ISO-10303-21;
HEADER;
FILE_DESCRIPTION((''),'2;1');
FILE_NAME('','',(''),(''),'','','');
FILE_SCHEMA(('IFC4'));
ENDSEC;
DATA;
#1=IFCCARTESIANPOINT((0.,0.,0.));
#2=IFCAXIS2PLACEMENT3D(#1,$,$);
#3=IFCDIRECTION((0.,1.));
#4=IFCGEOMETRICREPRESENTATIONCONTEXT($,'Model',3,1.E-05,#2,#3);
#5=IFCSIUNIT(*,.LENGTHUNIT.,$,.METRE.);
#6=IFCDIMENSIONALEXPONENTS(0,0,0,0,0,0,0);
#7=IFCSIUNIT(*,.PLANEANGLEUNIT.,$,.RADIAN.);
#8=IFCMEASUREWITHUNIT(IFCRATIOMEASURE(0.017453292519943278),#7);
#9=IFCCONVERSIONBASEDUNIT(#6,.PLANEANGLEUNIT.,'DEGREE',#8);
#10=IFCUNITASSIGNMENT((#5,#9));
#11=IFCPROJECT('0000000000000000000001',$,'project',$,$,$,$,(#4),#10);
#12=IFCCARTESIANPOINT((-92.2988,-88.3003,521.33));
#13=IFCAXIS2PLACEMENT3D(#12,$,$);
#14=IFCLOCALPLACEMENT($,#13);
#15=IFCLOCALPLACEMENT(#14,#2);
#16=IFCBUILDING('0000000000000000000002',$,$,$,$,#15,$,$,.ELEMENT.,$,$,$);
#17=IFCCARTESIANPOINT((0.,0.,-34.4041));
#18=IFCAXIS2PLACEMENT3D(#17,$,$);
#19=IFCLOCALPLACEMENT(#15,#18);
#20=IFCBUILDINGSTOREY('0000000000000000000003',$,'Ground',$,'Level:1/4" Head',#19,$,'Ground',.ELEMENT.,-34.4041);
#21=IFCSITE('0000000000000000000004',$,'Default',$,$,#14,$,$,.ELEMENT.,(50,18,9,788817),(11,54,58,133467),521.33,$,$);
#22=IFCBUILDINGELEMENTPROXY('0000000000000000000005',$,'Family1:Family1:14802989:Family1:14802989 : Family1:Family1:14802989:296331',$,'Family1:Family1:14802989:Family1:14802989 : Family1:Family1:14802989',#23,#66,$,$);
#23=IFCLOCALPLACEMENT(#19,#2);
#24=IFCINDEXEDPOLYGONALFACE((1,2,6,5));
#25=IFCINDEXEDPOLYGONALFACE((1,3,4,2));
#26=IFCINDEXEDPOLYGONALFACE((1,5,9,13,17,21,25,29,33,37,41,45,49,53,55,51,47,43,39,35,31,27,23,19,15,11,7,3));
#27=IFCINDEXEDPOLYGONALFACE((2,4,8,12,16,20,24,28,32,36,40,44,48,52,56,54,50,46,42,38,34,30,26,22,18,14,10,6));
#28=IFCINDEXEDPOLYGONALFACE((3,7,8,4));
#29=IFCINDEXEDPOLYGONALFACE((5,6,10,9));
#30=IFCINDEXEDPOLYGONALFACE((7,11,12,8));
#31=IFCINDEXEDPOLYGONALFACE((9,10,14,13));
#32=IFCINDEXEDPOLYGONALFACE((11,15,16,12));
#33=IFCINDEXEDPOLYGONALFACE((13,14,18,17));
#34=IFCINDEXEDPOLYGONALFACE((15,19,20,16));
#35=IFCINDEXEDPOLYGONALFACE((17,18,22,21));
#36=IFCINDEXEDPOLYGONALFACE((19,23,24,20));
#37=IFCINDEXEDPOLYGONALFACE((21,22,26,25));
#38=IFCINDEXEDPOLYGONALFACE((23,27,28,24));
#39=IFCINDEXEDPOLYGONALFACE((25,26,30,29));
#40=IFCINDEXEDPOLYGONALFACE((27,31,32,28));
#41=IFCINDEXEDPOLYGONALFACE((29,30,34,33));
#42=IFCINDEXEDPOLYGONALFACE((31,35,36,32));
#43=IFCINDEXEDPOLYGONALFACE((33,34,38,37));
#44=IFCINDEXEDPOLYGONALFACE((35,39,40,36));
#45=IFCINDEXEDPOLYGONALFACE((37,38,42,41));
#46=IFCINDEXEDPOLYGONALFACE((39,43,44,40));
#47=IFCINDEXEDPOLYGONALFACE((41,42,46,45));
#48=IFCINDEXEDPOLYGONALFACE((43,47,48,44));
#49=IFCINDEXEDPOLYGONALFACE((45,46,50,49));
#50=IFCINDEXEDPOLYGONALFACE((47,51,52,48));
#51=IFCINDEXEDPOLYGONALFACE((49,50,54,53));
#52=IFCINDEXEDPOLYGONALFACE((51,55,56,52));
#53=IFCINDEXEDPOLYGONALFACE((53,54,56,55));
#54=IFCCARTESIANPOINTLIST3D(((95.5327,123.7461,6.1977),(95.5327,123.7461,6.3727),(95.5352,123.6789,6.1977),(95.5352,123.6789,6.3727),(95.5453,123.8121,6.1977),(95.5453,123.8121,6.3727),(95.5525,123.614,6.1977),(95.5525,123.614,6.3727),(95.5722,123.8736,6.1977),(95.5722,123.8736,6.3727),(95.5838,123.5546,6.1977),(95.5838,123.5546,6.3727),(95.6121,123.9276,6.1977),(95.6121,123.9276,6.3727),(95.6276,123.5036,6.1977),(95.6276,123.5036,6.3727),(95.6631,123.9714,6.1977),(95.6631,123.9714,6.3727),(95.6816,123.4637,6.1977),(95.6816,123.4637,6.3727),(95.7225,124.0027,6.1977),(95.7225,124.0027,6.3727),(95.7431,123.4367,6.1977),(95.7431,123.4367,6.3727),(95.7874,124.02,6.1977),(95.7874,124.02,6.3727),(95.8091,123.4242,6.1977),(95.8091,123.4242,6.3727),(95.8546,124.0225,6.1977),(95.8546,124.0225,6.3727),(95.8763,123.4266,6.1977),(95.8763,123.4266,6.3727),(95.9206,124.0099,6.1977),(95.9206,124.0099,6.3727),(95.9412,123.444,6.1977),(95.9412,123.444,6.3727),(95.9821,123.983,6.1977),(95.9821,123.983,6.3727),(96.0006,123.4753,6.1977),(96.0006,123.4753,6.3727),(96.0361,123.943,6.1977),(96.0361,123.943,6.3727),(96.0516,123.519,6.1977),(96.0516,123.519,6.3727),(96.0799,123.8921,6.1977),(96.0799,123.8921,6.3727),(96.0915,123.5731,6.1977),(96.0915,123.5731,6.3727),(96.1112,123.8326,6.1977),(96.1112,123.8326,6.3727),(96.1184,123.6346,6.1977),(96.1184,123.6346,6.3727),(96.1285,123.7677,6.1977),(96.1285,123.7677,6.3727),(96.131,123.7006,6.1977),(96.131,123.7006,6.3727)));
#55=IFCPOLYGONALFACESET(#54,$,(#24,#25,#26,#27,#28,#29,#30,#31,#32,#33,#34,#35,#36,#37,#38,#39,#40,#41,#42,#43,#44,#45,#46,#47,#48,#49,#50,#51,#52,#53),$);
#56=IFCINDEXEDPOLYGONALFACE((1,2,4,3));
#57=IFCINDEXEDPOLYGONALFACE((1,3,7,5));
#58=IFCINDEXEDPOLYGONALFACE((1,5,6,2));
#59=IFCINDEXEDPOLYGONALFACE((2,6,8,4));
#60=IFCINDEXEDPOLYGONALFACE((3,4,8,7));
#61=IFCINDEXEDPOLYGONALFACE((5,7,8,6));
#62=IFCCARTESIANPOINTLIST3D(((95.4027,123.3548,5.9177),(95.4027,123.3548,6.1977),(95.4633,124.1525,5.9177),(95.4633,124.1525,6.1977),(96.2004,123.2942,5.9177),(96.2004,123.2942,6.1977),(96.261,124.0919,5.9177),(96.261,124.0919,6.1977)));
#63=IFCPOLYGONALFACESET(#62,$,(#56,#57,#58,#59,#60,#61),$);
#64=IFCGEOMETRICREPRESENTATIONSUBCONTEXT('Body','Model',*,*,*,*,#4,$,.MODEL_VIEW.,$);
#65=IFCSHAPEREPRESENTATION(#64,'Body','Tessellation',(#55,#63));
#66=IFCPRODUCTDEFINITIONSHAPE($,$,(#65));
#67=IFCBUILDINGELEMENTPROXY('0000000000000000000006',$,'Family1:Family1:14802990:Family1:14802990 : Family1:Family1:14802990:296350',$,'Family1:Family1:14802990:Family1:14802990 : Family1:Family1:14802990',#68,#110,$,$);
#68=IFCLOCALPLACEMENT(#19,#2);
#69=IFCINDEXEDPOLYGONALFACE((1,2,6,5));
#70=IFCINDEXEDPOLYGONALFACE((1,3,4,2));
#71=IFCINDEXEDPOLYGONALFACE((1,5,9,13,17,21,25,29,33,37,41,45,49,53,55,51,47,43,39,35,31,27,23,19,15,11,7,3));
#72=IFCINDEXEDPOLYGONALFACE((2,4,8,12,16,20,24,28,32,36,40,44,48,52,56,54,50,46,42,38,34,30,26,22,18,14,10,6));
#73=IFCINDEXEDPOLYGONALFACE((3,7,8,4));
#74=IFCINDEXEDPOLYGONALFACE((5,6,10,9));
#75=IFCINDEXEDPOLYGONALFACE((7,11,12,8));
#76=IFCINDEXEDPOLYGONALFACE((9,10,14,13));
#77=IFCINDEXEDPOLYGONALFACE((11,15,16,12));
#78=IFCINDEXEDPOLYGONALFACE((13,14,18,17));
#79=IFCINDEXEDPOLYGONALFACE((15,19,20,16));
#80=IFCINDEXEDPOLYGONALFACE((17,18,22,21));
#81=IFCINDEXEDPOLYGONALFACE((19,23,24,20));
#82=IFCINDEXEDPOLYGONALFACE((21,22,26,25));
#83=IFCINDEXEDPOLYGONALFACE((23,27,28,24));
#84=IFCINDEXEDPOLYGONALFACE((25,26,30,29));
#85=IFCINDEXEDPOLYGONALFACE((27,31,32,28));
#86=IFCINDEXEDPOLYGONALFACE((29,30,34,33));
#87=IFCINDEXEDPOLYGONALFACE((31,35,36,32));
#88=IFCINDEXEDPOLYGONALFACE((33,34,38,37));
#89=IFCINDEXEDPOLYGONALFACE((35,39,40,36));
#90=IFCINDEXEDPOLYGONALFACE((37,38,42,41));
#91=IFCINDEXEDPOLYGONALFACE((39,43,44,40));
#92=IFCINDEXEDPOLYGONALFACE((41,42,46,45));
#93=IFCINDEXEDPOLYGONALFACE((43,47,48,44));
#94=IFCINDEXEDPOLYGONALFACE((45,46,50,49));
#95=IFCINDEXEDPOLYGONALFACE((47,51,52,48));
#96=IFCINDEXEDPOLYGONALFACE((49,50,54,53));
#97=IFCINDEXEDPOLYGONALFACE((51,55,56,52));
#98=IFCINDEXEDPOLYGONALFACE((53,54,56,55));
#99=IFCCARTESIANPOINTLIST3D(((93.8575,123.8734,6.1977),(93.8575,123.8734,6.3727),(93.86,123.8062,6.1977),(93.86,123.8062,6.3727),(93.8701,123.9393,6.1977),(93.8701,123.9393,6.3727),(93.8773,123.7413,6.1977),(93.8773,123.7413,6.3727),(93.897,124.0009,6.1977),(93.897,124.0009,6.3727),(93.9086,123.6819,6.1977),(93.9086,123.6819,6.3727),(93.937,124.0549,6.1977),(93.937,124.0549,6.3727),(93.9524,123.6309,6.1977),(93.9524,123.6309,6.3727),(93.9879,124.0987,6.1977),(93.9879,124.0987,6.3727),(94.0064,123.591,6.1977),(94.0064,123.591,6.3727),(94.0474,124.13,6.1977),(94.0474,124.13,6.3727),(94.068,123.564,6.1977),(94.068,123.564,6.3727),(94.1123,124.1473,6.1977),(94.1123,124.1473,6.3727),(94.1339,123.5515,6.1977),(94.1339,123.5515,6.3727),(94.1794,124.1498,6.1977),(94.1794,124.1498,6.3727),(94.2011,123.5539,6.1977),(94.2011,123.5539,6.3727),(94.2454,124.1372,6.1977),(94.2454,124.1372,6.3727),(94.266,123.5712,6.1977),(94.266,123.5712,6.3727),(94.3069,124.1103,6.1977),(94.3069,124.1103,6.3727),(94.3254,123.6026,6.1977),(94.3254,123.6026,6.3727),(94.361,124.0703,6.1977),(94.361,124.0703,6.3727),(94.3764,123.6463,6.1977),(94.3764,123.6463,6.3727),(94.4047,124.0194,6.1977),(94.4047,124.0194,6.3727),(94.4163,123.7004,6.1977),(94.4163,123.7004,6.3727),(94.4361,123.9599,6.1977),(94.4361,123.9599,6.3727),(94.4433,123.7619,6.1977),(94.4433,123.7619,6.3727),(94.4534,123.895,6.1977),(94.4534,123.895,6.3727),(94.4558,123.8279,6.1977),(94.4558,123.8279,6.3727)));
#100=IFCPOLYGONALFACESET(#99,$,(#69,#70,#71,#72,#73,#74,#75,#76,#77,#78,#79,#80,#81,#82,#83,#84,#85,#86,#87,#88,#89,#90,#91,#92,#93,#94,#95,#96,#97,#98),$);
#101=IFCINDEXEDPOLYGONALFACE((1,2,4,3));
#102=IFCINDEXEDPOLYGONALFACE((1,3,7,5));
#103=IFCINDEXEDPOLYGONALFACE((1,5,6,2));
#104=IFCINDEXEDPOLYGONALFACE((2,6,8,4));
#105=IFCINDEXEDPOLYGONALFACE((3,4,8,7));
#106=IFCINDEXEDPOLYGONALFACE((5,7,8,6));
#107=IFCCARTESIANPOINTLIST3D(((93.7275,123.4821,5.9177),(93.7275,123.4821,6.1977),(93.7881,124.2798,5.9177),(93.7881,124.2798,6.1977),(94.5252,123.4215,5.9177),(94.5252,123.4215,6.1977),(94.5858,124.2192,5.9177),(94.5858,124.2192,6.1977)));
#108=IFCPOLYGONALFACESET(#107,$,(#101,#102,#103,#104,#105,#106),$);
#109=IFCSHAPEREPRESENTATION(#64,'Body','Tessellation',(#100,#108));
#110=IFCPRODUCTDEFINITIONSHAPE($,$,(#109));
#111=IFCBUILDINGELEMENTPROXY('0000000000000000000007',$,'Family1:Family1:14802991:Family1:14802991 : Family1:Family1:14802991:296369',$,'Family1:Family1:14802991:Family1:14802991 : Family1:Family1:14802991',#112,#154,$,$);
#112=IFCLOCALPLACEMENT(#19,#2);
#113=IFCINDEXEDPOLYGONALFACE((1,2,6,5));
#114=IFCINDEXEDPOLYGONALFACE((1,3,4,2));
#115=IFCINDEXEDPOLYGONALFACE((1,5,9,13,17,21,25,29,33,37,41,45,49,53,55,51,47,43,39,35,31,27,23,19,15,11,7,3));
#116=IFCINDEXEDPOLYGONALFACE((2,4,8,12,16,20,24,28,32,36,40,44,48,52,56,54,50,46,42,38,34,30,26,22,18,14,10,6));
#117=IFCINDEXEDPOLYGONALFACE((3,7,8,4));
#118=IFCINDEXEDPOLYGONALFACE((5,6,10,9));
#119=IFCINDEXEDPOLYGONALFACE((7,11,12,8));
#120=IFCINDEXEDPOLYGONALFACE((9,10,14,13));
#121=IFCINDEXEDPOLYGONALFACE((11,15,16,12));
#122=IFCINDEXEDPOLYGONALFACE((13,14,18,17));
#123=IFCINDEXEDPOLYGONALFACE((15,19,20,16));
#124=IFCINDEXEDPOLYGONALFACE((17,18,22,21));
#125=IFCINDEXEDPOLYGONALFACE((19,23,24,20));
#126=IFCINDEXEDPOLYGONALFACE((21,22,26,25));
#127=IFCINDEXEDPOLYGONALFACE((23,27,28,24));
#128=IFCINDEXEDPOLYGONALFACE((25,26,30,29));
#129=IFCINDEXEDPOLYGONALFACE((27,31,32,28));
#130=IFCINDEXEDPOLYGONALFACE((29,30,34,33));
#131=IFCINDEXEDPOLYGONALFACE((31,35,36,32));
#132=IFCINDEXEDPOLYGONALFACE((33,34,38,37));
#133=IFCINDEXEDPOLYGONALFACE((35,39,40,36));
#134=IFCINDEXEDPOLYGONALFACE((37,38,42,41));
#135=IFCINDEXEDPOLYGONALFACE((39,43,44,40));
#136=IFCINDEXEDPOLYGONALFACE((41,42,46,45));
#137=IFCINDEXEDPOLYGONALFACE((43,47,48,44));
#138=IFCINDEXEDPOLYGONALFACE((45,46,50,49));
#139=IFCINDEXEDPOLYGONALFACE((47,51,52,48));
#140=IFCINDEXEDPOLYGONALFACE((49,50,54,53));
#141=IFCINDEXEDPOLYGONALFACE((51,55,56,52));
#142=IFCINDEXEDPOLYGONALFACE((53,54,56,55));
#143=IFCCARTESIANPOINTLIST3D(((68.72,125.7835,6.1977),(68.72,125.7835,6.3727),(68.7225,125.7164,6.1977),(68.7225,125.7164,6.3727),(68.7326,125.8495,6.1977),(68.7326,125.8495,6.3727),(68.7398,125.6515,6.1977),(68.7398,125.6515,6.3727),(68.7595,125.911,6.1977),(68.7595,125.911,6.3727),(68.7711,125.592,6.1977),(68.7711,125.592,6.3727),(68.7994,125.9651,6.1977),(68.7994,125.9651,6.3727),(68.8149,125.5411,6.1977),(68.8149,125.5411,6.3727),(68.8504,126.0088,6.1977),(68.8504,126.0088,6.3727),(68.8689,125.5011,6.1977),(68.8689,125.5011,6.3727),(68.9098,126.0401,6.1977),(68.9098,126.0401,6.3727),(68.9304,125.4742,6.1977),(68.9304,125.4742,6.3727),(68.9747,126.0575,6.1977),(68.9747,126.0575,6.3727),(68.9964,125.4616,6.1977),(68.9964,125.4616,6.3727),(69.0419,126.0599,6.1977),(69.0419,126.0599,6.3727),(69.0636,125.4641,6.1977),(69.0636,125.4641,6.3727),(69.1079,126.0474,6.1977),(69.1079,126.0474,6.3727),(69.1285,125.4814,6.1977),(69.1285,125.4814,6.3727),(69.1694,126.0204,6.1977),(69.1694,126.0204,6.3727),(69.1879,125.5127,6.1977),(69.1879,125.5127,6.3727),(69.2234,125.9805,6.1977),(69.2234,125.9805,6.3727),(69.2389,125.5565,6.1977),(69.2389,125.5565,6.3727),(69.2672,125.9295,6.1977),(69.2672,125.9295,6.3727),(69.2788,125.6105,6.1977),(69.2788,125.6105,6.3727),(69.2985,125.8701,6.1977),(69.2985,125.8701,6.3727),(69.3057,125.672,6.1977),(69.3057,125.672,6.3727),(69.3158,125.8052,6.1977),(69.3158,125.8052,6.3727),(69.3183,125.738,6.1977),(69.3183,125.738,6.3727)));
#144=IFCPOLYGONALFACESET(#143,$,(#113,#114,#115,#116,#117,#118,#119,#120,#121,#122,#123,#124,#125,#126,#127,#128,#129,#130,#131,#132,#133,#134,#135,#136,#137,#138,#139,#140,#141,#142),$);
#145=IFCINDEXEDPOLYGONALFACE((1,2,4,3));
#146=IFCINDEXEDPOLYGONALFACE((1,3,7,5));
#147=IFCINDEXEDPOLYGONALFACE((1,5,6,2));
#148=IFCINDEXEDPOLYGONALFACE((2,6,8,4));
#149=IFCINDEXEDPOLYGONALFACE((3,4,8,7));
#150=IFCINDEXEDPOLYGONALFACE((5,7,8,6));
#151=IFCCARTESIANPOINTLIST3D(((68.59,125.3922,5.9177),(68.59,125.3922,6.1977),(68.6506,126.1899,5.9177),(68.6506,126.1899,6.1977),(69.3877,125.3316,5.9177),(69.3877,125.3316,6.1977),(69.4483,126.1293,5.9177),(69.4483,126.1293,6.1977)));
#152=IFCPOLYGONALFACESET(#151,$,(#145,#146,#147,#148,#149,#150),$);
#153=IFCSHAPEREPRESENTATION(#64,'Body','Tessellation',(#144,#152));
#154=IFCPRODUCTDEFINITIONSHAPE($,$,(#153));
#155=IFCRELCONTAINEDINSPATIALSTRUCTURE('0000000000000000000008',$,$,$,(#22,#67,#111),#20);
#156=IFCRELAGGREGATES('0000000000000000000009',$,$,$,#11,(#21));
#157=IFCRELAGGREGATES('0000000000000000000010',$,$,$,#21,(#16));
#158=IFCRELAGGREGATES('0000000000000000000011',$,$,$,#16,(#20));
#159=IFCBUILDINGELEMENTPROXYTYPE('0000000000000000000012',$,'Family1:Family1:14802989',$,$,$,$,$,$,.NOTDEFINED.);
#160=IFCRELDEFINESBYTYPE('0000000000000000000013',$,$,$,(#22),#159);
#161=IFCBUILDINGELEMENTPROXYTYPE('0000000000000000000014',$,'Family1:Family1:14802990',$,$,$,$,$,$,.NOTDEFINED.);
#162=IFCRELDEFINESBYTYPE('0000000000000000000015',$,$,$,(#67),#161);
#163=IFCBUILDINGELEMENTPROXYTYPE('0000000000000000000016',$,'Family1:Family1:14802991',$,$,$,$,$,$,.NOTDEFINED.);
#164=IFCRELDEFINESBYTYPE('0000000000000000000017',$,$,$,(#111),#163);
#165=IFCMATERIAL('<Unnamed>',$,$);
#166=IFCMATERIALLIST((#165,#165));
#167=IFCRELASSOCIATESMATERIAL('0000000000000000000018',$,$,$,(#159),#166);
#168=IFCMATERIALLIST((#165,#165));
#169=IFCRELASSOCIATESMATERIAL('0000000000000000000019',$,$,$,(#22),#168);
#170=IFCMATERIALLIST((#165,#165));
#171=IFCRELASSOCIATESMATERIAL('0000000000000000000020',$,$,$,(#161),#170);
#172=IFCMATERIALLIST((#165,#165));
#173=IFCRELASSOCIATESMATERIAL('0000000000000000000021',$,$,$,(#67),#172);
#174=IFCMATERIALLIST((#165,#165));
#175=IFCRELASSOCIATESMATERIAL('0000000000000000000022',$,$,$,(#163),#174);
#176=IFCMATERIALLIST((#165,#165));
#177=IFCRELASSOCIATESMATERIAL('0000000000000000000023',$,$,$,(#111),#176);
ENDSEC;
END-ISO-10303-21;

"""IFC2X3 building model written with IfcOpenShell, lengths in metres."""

from ifc_helpers import new_model, entity, si_unit, converted_unit, direction, frame, frame_2d, origin, origin_2d_with_axis, place, context, subcontext, project, spatial, rectangle, circle, extrude, source, transform, mapped, material, material_list, type_object, type_shapes, element, save


model = new_model("IFC2X3")

# Units and contexts
model_context = context("Model", 3, precision=1e-05, world=origin(), true_north=direction((0.0, 1.0)))
body_context = subcontext(model_context, "Body", "Model", "MODEL_VIEW")
ifc_project = project(units=[si_unit("LENGTHUNIT", "METRE"), converted_unit("PLANEANGLEUNIT", "DEGREE", entity("IfcRatioMeasure", 0.017453292519943278), si_unit("PLANEANGLEUNIT", "RADIAN"), dimensions=[0, 0, 0, 0, 0, 0, 0])], contexts=[model_context])

# Site, building, storey
site_placement = place(None, frame((-92.2988, -88.3003, 521.33)))
site = spatial("IfcSite", under=ifc_project, at=site_placement, Name="Default", CompositionType="ELEMENT", RefLatitude=(50, 18, 9, 788817), RefLongitude=(11, 54, 58, 133467), RefElevation=521.33)
building_placement = place(site_placement, origin())
building = spatial("IfcBuilding", under=site, at=building_placement, CompositionType="ELEMENT")
storey_placement = place(building_placement, frame((0.0, 0.0, -34.4041)))
storey = spatial("IfcBuildingStorey", under=building, at=storey_placement, Name="Ground", ObjectType="Level:1/4\" Head", LongName="Ground", CompositionType="ELEMENT", Elevation=-34.4041)

# Building element proxies
ifc_material_1 = material(Name="<Unnamed>")
ifc_material_list_1 = material_list([ifc_material_1, ifc_material_1])
ifc_material_list_2 = material_list([ifc_material_1, ifc_material_1])
building_element_proxy_type_1 = type_object("IfcBuildingElementProxyType", Name="Family1:Family1:14802989", PredefinedType="NOTDEFINED", material=ifc_material_list_2)
shared_shape_1 = source(origin(), body_context, "Body", "SweptSolid", [
    extrude(circle(Radius=0.3, at=frame_2d((0.0, 0.0), x_axis=(1.0, 0.0))), frame((95.8318, 123.7233, -28.2064), z_axis=(0.0, 0.0, 1.0), x_axis=(0.997125, -0.07577, 0.0)), (0.0, 0.0, 1.0), 0.175),
    extrude(rectangle(XDim=0.8, YDim=0.8, at=frame_2d((0.0, 0.0), x_axis=(1.0, 0.0))), frame((95.8318, 123.7233, -28.4864), z_axis=(0.0, 0.0, 1.0), x_axis=(-0.07577, -0.997125, 0.0)), (0.0, 0.0, 1.0), 0.28),
])
type_shapes(building_element_proxy_type_1, [shared_shape_1])
proxy_1_placement = place(storey_placement, frame((0.0, 0.0, 34.4041)))
element("IfcBuildingElementProxy", 1, at=proxy_1_placement, inside=storey, type_object=building_element_proxy_type_1, material=ifc_material_list_1, Name="Family1:Family1:14802989:Family1:14802989 : Family1:Family1:14802989:296331", ObjectType="Family1:Family1:14802989:Family1:14802989 : Family1:Family1:14802989", context=body_context, shape_type="MappedRepresentation", body=[
    mapped(shared_shape_1, transform((0.0, 0.0, 0.0), scale=1.0)),
])
ifc_material_list_3 = material_list([ifc_material_1, ifc_material_1])
ifc_material_list_4 = material_list([ifc_material_1, ifc_material_1])
building_element_proxy_type_2 = type_object("IfcBuildingElementProxyType", Name="Family1:Family1:14802990", PredefinedType="NOTDEFINED", material=ifc_material_list_4)
shared_shape_2 = source(origin(), body_context, "Body", "SweptSolid", [
    extrude(circle(Radius=0.3, at=frame_2d((0.0, 0.0), x_axis=(1.0, 0.0))), frame((94.1567, 123.8506, -28.2064), z_axis=(0.0, 0.0, 1.0), x_axis=(0.997125, -0.07577, 0.0)), (0.0, 0.0, 1.0), 0.175),
    extrude(rectangle(XDim=0.8, YDim=0.8, at=frame_2d((0.0, 0.0), x_axis=(1.0, 0.0))), frame((94.1567, 123.8506, -28.4864), z_axis=(0.0, 0.0, 1.0), x_axis=(-0.07577, -0.997125, 0.0)), (0.0, 0.0, 1.0), 0.28),
])
type_shapes(building_element_proxy_type_2, [shared_shape_2])
proxy_2_placement = place(storey_placement, frame((0.0, 0.0, 34.4041)))
element("IfcBuildingElementProxy", 2, at=proxy_2_placement, inside=storey, type_object=building_element_proxy_type_2, material=ifc_material_list_3, Name="Family1:Family1:14802990:Family1:14802990 : Family1:Family1:14802990:296350", ObjectType="Family1:Family1:14802990:Family1:14802990 : Family1:Family1:14802990", context=body_context, shape_type="MappedRepresentation", body=[
    mapped(shared_shape_2, transform((0.0, 0.0, 0.0), scale=1.0)),
])
ifc_material_list_5 = material_list([ifc_material_1, ifc_material_1])
ifc_material_list_6 = material_list([ifc_material_1, ifc_material_1])
building_element_proxy_type_3 = type_object("IfcBuildingElementProxyType", Name="Family1:Family1:14802991", PredefinedType="NOTDEFINED", material=ifc_material_list_6)
shared_shape_3 = source(origin(), body_context, "Body", "SweptSolid", [
    extrude(circle(Radius=0.3, at=origin_2d_with_axis()), frame((69.0191, 125.7608, -28.2064), z_axis=(0.0, 0.0, 1.0), x_axis=(0.997125, -0.07577, 0.0)), (0.0, 0.0, 1.0), 0.175),
    extrude(rectangle(XDim=0.8, YDim=0.8, at=frame_2d((0.0, 0.0), x_axis=(1.0, 0.0))), frame((69.0191, 125.7608, -28.4864), z_axis=(0.0, 0.0, 1.0), x_axis=(-0.07577, -0.997125, 0.0)), (0.0, 0.0, 1.0), 0.28),
])
type_shapes(building_element_proxy_type_3, [shared_shape_3])
proxy_3_placement = place(storey_placement, frame((0.0, 0.0, 34.4041)))
element("IfcBuildingElementProxy", 3, at=proxy_3_placement, inside=storey, type_object=building_element_proxy_type_3, material=ifc_material_list_5, Name="Family1:Family1:14802991:Family1:14802991 : Family1:Family1:14802991:296369", ObjectType="Family1:Family1:14802991:Family1:14802991 : Family1:Family1:14802991", context=body_context, shape_type="MappedRepresentation", body=[
    mapped(shared_shape_3, transform((0.0, 0.0, 0.0), scale=1.0)),
])

save(model, "model.ifc")
